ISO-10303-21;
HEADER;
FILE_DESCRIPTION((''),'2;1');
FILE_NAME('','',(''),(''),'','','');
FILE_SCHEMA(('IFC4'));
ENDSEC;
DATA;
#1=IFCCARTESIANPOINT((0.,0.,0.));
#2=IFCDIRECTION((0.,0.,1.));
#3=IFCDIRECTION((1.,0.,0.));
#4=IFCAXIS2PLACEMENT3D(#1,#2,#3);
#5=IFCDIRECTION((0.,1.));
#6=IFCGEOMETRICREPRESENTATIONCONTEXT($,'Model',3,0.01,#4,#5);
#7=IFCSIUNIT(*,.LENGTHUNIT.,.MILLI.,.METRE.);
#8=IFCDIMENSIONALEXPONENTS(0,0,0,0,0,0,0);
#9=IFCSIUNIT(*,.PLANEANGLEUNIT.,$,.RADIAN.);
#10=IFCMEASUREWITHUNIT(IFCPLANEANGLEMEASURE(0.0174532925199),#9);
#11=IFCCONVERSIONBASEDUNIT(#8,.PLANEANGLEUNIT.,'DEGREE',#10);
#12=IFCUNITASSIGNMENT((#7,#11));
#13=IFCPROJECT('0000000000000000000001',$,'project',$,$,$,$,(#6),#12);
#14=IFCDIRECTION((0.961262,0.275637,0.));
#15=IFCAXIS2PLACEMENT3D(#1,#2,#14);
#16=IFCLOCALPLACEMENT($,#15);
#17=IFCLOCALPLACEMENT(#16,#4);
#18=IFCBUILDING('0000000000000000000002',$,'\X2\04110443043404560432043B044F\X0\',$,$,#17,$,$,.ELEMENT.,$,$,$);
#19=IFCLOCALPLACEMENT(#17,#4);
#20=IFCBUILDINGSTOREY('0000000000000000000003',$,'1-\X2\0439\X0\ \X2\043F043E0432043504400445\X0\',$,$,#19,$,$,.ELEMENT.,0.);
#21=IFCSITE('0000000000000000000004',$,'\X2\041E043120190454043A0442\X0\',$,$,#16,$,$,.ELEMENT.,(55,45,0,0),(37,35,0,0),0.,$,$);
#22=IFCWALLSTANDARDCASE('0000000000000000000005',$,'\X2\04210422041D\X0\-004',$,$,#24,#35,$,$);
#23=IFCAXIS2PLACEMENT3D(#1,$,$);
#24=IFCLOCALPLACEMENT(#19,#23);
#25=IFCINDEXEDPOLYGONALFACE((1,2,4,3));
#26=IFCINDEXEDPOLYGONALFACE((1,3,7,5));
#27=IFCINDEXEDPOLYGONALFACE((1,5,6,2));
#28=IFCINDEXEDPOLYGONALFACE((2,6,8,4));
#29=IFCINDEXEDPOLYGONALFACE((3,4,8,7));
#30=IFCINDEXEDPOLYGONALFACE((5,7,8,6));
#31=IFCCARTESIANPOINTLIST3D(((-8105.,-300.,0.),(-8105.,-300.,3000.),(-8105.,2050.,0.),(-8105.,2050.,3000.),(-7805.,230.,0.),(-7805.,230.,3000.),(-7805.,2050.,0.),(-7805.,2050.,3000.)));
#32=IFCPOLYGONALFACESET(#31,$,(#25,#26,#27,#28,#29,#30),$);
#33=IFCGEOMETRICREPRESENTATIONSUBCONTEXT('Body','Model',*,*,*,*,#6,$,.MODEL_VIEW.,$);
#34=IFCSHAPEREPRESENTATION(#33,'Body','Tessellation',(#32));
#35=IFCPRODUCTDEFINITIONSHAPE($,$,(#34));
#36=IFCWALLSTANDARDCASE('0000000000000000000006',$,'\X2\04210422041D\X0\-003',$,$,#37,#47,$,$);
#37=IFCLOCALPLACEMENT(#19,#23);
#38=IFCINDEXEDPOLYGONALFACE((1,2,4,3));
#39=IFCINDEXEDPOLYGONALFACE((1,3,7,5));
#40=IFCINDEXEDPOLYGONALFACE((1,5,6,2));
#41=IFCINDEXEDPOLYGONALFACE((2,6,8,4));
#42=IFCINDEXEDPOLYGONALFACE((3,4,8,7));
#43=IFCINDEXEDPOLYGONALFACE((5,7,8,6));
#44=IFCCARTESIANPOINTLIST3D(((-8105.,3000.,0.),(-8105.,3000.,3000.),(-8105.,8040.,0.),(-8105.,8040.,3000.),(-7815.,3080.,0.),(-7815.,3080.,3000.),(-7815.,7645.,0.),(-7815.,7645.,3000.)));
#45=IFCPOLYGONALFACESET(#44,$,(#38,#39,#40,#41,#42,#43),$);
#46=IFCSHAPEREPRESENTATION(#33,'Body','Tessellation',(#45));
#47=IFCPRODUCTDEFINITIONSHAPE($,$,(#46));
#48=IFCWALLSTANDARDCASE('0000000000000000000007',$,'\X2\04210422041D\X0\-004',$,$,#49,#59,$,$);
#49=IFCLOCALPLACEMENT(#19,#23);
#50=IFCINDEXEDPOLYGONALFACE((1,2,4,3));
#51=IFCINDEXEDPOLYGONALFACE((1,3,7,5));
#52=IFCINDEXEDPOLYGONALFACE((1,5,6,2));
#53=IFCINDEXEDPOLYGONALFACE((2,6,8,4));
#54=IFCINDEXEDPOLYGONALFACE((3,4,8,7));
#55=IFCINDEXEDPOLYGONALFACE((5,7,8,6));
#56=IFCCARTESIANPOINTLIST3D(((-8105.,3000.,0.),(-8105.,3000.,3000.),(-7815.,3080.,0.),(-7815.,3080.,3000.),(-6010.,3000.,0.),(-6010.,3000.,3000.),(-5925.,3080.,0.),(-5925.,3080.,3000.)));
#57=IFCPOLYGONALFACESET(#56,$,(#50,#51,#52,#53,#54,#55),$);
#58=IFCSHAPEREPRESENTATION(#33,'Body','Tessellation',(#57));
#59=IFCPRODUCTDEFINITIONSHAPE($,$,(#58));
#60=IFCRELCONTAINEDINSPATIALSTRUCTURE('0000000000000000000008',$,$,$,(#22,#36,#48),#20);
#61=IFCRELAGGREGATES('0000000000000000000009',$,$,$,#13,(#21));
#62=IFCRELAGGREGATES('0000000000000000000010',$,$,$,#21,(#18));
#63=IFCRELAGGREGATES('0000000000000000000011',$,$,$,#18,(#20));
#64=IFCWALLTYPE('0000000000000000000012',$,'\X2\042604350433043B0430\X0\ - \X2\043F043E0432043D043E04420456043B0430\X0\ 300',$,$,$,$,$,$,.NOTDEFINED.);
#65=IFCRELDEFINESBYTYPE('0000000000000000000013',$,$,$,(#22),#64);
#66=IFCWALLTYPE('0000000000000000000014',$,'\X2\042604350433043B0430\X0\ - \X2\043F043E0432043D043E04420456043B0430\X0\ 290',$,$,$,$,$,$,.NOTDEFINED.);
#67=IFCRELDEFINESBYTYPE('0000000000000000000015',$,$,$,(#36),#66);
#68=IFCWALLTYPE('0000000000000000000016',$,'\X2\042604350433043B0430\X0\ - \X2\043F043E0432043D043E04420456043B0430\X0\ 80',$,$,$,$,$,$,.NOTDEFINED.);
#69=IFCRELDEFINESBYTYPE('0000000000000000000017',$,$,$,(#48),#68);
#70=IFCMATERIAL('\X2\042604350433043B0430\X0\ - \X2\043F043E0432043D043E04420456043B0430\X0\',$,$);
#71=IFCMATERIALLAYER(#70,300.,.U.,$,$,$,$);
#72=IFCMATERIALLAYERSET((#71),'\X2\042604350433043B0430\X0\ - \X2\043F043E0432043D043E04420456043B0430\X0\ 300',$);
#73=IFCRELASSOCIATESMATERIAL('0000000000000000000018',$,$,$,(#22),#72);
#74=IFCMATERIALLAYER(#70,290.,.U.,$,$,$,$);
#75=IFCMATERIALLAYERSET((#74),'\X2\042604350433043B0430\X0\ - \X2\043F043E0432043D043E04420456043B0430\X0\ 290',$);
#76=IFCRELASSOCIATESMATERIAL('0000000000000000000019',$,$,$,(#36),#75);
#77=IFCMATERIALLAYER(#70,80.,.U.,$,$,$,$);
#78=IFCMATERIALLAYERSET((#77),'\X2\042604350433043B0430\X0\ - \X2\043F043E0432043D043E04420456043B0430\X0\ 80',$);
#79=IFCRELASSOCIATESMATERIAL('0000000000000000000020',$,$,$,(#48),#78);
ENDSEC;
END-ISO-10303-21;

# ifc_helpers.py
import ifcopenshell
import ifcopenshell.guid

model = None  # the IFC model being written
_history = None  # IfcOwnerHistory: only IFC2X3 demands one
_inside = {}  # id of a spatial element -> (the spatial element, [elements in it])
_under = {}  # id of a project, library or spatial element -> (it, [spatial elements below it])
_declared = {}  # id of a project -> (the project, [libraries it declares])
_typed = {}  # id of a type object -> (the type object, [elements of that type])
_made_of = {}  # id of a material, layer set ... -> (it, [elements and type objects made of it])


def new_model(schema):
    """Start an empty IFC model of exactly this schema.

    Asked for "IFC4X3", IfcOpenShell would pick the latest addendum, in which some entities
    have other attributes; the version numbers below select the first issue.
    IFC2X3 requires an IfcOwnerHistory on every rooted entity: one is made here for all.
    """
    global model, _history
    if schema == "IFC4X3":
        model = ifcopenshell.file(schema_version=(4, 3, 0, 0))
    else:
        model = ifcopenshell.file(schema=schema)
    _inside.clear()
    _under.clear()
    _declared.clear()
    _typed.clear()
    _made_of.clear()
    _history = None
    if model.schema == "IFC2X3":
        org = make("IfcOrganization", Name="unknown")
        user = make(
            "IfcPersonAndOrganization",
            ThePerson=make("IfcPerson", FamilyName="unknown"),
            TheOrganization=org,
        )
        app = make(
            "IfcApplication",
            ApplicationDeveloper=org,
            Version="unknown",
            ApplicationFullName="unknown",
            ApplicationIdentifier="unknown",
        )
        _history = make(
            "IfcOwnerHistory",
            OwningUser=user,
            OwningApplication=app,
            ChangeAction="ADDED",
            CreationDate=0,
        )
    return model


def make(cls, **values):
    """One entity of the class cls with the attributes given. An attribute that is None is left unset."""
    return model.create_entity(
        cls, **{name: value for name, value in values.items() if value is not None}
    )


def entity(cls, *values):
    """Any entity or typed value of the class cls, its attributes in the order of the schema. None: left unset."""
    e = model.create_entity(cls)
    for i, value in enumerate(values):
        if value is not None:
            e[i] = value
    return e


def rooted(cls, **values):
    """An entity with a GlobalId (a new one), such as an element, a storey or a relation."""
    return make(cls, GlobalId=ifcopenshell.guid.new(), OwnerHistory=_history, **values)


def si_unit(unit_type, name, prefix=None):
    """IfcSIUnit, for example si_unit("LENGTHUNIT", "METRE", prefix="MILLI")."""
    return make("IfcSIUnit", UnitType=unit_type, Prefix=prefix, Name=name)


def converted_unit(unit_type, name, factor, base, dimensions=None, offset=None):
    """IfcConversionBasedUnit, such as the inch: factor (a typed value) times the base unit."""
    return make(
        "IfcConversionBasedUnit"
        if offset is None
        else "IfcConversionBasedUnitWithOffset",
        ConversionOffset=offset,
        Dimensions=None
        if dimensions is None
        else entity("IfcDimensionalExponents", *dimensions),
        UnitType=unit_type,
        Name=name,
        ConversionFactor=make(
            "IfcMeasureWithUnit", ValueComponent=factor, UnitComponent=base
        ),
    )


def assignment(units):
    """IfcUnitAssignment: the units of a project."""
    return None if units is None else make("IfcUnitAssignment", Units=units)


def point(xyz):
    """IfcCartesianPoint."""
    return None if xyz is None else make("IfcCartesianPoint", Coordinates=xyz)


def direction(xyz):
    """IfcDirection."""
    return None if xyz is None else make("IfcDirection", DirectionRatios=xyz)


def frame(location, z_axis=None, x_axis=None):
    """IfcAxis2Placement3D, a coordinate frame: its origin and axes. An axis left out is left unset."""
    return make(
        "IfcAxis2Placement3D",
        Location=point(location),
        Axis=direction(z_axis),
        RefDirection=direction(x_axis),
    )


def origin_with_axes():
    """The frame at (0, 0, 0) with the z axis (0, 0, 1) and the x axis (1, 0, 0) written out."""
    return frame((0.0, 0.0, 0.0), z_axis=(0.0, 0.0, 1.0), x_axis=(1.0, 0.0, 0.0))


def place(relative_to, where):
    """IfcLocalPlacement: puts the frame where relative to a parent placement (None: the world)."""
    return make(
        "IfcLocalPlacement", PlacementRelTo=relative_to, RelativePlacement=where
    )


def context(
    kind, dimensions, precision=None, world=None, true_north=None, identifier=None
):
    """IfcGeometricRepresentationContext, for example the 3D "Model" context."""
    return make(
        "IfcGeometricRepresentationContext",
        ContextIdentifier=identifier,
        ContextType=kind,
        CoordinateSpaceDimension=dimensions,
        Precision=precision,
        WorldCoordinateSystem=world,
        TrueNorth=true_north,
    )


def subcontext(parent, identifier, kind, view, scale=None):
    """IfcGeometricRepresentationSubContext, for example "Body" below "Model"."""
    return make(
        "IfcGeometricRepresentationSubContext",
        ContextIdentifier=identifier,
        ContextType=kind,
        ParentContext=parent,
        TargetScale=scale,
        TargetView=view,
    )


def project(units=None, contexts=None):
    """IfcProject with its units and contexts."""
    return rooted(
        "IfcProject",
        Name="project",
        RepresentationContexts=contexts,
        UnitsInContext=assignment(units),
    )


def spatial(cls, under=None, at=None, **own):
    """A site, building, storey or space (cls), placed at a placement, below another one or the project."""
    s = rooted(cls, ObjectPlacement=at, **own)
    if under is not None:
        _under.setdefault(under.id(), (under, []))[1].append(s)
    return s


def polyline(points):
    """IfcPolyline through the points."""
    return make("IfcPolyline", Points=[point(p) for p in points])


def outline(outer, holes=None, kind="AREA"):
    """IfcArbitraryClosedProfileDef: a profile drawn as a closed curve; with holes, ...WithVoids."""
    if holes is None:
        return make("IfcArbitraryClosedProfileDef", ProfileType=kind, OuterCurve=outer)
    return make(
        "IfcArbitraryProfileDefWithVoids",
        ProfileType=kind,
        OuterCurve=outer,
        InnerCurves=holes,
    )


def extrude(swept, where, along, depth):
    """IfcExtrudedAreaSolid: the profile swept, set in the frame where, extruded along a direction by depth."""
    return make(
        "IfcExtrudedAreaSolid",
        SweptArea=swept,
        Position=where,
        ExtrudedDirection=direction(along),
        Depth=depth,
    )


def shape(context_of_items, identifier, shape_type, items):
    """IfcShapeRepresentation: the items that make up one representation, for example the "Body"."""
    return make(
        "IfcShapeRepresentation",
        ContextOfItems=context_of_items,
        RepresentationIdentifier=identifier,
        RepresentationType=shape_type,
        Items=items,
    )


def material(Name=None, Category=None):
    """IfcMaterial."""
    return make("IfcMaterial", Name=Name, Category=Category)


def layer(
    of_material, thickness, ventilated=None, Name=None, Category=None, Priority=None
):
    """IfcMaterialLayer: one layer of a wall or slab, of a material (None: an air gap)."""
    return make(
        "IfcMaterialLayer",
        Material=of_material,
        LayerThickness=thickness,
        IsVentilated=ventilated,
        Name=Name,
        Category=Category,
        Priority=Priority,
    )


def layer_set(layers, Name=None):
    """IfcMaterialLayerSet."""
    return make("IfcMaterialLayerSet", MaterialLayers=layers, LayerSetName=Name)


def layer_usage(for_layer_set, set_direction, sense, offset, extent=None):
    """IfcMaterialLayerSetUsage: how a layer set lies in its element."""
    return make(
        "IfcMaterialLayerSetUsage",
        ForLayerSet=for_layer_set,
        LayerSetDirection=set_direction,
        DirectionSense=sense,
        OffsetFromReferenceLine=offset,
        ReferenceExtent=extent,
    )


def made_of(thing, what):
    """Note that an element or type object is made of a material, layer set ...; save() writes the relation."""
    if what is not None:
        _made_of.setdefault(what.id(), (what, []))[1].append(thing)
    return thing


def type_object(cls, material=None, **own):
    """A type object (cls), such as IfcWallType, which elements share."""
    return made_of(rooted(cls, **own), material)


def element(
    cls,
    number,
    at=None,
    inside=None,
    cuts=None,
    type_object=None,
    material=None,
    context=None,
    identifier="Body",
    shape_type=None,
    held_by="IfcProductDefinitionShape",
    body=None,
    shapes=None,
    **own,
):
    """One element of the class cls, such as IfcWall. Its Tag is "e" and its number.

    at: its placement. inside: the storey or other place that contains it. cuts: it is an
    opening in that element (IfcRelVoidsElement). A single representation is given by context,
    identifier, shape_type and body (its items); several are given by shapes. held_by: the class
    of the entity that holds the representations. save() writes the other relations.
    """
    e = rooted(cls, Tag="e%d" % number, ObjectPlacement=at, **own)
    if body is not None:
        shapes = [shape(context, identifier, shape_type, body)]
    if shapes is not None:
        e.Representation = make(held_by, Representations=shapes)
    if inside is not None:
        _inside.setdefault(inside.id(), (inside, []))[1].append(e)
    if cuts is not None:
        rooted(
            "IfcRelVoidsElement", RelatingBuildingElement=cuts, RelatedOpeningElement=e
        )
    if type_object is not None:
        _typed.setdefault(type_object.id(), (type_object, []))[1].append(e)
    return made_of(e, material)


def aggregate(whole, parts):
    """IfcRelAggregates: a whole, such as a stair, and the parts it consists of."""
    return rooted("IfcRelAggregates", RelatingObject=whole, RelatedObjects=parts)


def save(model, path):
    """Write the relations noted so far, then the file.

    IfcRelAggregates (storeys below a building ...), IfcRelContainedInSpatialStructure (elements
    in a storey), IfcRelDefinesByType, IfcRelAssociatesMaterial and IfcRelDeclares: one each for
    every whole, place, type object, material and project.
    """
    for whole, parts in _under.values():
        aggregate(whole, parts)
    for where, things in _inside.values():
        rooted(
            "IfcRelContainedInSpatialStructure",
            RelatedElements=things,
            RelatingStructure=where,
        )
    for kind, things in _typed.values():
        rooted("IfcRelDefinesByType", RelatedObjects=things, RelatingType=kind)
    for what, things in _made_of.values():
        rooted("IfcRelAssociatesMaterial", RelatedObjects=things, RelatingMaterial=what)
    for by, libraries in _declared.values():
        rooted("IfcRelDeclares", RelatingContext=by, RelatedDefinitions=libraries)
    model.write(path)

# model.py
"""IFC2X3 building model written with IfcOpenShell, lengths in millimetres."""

from ifc_helpers import new_model, entity, si_unit, converted_unit, direction, frame, origin_with_axes, place, context, subcontext, project, spatial, polyline, outline, extrude, material, layer, layer_set, layer_usage, type_object, element, save


model = new_model("IFC2X3")

# Units and contexts
model_context = context("Model", 3, precision=0.01, world=origin_with_axes(), true_north=direction((0.0, 1.0)))
body_context = subcontext(model_context, "Body", "Model", "MODEL_VIEW")
ifc_project = project(units=[si_unit("LENGTHUNIT", "METRE", prefix="MILLI"), converted_unit("PLANEANGLEUNIT", "DEGREE", entity("IfcPlaneAngleMeasure", 0.0174532925199), si_unit("PLANEANGLEUNIT", "RADIAN"), dimensions=[0, 0, 0, 0, 0, 0, 0])], contexts=[model_context])

# Site, building, storey
site_placement = place(None, frame((0.0, 0.0, 0.0), z_axis=(0.0, 0.0, 1.0), x_axis=(0.961262, 0.275637, 0.0)))
site = spatial("IfcSite", under=ifc_project, at=site_placement, Name="Об’єкт", CompositionType="ELEMENT", RefLatitude=(55, 45, 0, 0), RefLongitude=(37, 35, 0, 0), RefElevation=0.0)
building_placement = place(site_placement, origin_with_axes())
building = spatial("IfcBuilding", under=site, at=building_placement, Name="Будівля", CompositionType="ELEMENT")
storey_placement = place(building_placement, origin_with_axes())
storey = spatial("IfcBuildingStorey", under=building, at=storey_placement, Name="1-й поверх", CompositionType="ELEMENT", Elevation=0.0)

# Walls
ifc_material_1 = material(Name="Цегла - повнотіла")
ifc_layer_1 = layer(ifc_material_1, 300.0, ventilated="UNKNOWN")
ifc_layer_set_1 = layer_set([ifc_layer_1], Name="Цегла - повнотіла 300")
ifc_layer_usage_1 = layer_usage(ifc_layer_set_1, "AXIS2", "POSITIVE", 0.0)
wall_type_1 = type_object("IfcWallType", Name="Цегла - повнотіла 300", PredefinedType="NOTDEFINED")
wall_1_placement = place(storey_placement, frame((-8105.0, 2050.0, 0.0), z_axis=(0.0, 0.0, 1.0), x_axis=(0.0, -1.0, 0.0)))
element("IfcWallStandardCase", 1, at=wall_1_placement, inside=storey, type_object=wall_type_1, material=ifc_layer_usage_1, Name="СТН-004", context=body_context, shape_type="SweptSolid", body=[
    extrude(outline(polyline([(0.0, 0.0), (2350.0, 0.0), (1820.0, 300.0), (0.0, 300.0), (0.0, 0.0)])), origin_with_axes(), (0.0, 0.0, 1.0), 3000.0),
])
ifc_layer_2 = layer(ifc_material_1, 290.0, ventilated="UNKNOWN")
ifc_layer_set_2 = layer_set([ifc_layer_2], Name="Цегла - повнотіла 290")
ifc_layer_usage_2 = layer_usage(ifc_layer_set_2, "AXIS2", "POSITIVE", 0.0)
wall_type_2 = type_object("IfcWallType", Name="Цегла - повнотіла 290", PredefinedType="NOTDEFINED")
wall_2_placement = place(storey_placement, frame((-8105.0, 8040.0, 0.0), z_axis=(0.0, 0.0, 1.0), x_axis=(0.0, -1.0, 0.0)))
element("IfcWallStandardCase", 2, at=wall_2_placement, inside=storey, type_object=wall_type_2, material=ifc_layer_usage_2, Name="СТН-003", context=body_context, shape_type="SweptSolid", body=[
    extrude(outline(polyline([(0.0, 0.0), (5040.0, 0.0), (4960.0, 290.0), (395.0, 290.0), (0.0, 0.0)])), origin_with_axes(), (0.0, 0.0, 1.0), 3000.0),
])
ifc_layer_3 = layer(ifc_material_1, 80.0, ventilated="UNKNOWN")
ifc_layer_set_3 = layer_set([ifc_layer_3], Name="Цегла - повнотіла 80")
ifc_layer_usage_3 = layer_usage(ifc_layer_set_3, "AXIS2", "POSITIVE", 0.0)
wall_type_3 = type_object("IfcWallType", Name="Цегла - повнотіла 80", PredefinedType="NOTDEFINED")
wall_3_placement = place(storey_placement, frame((-6010.0, 3080.0, 0.0), z_axis=(0.0, 0.0, 1.0), x_axis=(-1.0, 0.0, 0.0)))
element("IfcWallStandardCase", 3, at=wall_3_placement, inside=storey, type_object=wall_type_3, material=ifc_layer_usage_3, Name="СТН-004", context=body_context, shape_type="SweptSolid", body=[
    extrude(outline(polyline([(-85.0, 0.0), (1805.0, 0.0), (2095.0, 80.0), (0.0, 80.0), (-85.0, 0.0)])), origin_with_axes(), (0.0, 0.0, 1.0), 3000.0),
])

save(model, "model.ifc")
